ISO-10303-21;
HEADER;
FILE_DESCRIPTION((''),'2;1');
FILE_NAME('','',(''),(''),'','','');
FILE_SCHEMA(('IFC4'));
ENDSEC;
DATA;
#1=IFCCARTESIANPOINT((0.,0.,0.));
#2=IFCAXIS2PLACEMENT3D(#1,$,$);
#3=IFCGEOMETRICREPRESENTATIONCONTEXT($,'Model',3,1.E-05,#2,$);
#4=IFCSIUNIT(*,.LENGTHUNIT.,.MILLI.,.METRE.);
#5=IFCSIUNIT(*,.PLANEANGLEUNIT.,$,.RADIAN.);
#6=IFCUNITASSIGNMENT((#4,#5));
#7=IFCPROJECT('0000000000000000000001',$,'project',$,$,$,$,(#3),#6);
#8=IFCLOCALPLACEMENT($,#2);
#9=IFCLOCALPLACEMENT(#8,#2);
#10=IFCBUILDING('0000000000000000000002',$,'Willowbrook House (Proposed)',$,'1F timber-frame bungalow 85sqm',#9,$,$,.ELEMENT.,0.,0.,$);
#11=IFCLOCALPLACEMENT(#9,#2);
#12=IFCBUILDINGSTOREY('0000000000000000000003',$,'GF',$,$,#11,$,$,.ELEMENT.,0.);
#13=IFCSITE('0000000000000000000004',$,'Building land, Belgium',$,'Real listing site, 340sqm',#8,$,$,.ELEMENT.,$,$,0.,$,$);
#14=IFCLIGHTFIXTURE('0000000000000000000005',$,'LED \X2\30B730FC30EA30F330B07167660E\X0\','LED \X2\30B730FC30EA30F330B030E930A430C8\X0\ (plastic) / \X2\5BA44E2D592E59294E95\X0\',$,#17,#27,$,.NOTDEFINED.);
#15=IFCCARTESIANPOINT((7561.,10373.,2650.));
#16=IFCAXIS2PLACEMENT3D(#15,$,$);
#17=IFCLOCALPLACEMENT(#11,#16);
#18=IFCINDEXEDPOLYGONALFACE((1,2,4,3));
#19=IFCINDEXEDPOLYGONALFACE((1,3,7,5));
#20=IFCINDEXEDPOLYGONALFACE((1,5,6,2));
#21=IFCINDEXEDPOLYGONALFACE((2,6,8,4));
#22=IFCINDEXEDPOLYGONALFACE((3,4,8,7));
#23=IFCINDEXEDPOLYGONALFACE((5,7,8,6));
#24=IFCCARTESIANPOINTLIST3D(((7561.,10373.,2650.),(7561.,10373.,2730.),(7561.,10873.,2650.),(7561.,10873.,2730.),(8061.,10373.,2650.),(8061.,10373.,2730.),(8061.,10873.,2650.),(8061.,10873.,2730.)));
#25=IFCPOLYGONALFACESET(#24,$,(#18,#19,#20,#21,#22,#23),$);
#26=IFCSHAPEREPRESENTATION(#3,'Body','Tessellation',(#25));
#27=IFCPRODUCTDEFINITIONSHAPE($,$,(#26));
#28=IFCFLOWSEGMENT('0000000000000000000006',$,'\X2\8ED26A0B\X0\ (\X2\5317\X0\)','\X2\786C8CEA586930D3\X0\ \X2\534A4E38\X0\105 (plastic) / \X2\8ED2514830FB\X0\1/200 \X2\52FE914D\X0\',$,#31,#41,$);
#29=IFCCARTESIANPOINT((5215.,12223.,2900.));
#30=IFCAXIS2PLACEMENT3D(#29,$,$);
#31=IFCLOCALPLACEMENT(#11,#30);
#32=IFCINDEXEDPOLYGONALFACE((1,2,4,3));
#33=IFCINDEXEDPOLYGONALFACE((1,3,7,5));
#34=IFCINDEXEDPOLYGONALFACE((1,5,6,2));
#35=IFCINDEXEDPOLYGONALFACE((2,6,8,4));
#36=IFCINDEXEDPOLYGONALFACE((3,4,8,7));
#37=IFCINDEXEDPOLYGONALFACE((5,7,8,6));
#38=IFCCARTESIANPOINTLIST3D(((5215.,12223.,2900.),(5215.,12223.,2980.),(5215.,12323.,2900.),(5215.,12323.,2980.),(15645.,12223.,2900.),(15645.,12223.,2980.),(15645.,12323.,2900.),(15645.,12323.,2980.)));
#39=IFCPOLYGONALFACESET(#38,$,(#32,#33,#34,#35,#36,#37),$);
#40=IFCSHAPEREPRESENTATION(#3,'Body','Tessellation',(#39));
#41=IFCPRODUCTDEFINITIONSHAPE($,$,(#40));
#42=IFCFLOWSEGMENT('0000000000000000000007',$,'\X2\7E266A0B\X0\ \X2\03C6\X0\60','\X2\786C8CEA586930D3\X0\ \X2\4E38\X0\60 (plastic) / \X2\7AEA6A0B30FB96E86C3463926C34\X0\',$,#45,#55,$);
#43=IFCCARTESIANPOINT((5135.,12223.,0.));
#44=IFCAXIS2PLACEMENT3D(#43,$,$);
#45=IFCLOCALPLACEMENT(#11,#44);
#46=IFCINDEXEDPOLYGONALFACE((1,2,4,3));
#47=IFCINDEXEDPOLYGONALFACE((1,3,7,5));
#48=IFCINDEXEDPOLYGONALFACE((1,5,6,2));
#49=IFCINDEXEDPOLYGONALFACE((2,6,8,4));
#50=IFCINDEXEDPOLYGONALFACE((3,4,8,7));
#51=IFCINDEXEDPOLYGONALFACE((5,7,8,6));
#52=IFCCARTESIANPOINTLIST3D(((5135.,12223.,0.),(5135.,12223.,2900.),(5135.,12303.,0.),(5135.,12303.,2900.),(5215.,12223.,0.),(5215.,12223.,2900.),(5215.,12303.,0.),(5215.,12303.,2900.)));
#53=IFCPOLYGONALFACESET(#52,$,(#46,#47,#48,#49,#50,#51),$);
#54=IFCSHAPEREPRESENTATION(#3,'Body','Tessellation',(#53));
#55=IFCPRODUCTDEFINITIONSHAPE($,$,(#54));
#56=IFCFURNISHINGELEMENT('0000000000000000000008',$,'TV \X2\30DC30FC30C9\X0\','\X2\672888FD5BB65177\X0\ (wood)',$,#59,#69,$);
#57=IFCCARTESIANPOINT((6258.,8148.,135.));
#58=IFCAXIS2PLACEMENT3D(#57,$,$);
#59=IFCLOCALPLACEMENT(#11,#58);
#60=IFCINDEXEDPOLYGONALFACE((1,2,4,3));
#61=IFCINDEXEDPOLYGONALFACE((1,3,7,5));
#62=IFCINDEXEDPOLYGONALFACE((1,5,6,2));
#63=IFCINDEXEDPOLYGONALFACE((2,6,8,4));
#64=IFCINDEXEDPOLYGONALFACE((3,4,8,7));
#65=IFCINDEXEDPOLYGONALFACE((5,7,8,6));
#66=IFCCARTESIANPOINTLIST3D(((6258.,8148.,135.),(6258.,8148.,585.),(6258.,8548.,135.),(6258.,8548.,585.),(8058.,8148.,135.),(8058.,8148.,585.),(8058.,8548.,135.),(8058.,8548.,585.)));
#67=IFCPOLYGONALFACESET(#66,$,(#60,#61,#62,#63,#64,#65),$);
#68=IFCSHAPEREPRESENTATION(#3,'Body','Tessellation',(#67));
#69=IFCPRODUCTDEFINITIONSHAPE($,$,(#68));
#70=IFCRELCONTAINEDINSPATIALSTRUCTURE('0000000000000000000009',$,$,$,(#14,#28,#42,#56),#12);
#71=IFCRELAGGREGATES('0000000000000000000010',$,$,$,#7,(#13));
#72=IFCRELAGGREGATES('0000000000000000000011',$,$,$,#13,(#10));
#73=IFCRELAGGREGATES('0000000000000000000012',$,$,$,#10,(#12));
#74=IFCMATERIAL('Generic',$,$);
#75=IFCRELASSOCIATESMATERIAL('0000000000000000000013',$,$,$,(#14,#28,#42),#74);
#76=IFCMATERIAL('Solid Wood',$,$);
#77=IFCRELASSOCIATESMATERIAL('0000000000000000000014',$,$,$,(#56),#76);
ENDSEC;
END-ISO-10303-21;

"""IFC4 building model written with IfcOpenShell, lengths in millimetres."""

from ifc_helpers import new_model, si_unit, frame, frame_2d, origin, place, context, project, spatial, rectangle, extrude, material, element, save


model = new_model("IFC4")

# Units and contexts
model_context = context("Model", 3, precision=1e-05, world=origin())
ifc_project = project(units=[si_unit("LENGTHUNIT", "METRE", prefix="MILLI"), si_unit("PLANEANGLEUNIT", "RADIAN")], contexts=[model_context])

# Site, building, storey
site_placement = place(None, origin())
site = spatial("IfcSite", under=ifc_project, at=site_placement, Name="Building land, Belgium", ObjectType="Real listing site, 340sqm", CompositionType="ELEMENT", RefElevation=0.0)
building_placement = place(site_placement, origin())
building = spatial("IfcBuilding", under=site, at=building_placement, Name="Willowbrook House (Proposed)", ObjectType="1F timber-frame bungalow 85sqm", CompositionType="ELEMENT", ElevationOfRefHeight=0.0, ElevationOfTerrain=0.0)
storey_placement = place(building_placement, origin())
storey = spatial("IfcBuildingStorey", under=building, at=storey_placement, Name="GF", CompositionType="ELEMENT", Elevation=0.0)

# Shared definitions
ifc_material_1 = material(Name="Solid Wood")

# Shared definitions
ifc_material_2 = material(Name="Generic")

# Light fixture
light_fixture_placement = place(storey_placement, frame((7561.0, 10373.0, 2650.0)))
element("IfcLightFixture", 1, at=light_fixture_placement, inside=storey, material=ifc_material_2, Name="LED シーリング照明", Description="LED シーリングライト (plastic) / 室中央天井", PredefinedType="NOTDEFINED", context=model_context, shape_type="SweptSolid", body=[
    extrude(rectangle(XDim=500.0, YDim=500.0, at=frame_2d((250.0, 250.0))), frame((7561.0, 10373.0, 2650.0)), (0.0, 0.0, 1.0), 80.0),
])

# Flow segments
flow_segment_1_placement = place(storey_placement, frame((5215.0, 12223.0, 2900.0)))
element("IfcFlowSegment", 2, at=flow_segment_1_placement, inside=storey, material=ifc_material_2, Name="軒樋 (北)", Description="硬質塩ビ 半丸105 (plastic) / 軒先・1/200 勾配", context=model_context, shape_type="SweptSolid", body=[
    extrude(rectangle(XDim=10430.0, YDim=100.0, at=frame_2d((5215.0, 50.0))), frame((5215.0, 12223.0, 2900.0)), (0.0, 0.0, 1.0), 80.0),
])
flow_segment_2_placement = place(storey_placement, frame((5135.0, 12223.0, 0.0)))
element("IfcFlowSegment", 3, at=flow_segment_2_placement, inside=storey, material=ifc_material_2, Name="縦樋 φ60", Description="硬質塩ビ 丸60 (plastic) / 竪樋・雨水排水", context=model_context, shape_type="SweptSolid", body=[
    extrude(rectangle(XDim=80.0, YDim=80.0, at=frame_2d((40.0, 40.0))), frame((5135.0, 12223.0, 0.0)), (0.0, 0.0, 1.0), 2900.0),
])

# Furnishing element
furnishing_placement = place(storey_placement, frame((6258.0, 8148.0, 135.0)))
element("IfcFurnishingElement", 4, at=furnishing_placement, inside=storey, material=ifc_material_1, Name="TV ボード", Description="木製家具 (wood)", context=model_context, shape_type="SweptSolid", body=[
    extrude(rectangle(XDim=1800.0, YDim=400.0, at=frame_2d((900.0, 200.0))), frame((6258.0, 8148.0, 135.0)), (0.0, 0.0, 1.0), 450.0),
])

save(model, "model.ifc")
